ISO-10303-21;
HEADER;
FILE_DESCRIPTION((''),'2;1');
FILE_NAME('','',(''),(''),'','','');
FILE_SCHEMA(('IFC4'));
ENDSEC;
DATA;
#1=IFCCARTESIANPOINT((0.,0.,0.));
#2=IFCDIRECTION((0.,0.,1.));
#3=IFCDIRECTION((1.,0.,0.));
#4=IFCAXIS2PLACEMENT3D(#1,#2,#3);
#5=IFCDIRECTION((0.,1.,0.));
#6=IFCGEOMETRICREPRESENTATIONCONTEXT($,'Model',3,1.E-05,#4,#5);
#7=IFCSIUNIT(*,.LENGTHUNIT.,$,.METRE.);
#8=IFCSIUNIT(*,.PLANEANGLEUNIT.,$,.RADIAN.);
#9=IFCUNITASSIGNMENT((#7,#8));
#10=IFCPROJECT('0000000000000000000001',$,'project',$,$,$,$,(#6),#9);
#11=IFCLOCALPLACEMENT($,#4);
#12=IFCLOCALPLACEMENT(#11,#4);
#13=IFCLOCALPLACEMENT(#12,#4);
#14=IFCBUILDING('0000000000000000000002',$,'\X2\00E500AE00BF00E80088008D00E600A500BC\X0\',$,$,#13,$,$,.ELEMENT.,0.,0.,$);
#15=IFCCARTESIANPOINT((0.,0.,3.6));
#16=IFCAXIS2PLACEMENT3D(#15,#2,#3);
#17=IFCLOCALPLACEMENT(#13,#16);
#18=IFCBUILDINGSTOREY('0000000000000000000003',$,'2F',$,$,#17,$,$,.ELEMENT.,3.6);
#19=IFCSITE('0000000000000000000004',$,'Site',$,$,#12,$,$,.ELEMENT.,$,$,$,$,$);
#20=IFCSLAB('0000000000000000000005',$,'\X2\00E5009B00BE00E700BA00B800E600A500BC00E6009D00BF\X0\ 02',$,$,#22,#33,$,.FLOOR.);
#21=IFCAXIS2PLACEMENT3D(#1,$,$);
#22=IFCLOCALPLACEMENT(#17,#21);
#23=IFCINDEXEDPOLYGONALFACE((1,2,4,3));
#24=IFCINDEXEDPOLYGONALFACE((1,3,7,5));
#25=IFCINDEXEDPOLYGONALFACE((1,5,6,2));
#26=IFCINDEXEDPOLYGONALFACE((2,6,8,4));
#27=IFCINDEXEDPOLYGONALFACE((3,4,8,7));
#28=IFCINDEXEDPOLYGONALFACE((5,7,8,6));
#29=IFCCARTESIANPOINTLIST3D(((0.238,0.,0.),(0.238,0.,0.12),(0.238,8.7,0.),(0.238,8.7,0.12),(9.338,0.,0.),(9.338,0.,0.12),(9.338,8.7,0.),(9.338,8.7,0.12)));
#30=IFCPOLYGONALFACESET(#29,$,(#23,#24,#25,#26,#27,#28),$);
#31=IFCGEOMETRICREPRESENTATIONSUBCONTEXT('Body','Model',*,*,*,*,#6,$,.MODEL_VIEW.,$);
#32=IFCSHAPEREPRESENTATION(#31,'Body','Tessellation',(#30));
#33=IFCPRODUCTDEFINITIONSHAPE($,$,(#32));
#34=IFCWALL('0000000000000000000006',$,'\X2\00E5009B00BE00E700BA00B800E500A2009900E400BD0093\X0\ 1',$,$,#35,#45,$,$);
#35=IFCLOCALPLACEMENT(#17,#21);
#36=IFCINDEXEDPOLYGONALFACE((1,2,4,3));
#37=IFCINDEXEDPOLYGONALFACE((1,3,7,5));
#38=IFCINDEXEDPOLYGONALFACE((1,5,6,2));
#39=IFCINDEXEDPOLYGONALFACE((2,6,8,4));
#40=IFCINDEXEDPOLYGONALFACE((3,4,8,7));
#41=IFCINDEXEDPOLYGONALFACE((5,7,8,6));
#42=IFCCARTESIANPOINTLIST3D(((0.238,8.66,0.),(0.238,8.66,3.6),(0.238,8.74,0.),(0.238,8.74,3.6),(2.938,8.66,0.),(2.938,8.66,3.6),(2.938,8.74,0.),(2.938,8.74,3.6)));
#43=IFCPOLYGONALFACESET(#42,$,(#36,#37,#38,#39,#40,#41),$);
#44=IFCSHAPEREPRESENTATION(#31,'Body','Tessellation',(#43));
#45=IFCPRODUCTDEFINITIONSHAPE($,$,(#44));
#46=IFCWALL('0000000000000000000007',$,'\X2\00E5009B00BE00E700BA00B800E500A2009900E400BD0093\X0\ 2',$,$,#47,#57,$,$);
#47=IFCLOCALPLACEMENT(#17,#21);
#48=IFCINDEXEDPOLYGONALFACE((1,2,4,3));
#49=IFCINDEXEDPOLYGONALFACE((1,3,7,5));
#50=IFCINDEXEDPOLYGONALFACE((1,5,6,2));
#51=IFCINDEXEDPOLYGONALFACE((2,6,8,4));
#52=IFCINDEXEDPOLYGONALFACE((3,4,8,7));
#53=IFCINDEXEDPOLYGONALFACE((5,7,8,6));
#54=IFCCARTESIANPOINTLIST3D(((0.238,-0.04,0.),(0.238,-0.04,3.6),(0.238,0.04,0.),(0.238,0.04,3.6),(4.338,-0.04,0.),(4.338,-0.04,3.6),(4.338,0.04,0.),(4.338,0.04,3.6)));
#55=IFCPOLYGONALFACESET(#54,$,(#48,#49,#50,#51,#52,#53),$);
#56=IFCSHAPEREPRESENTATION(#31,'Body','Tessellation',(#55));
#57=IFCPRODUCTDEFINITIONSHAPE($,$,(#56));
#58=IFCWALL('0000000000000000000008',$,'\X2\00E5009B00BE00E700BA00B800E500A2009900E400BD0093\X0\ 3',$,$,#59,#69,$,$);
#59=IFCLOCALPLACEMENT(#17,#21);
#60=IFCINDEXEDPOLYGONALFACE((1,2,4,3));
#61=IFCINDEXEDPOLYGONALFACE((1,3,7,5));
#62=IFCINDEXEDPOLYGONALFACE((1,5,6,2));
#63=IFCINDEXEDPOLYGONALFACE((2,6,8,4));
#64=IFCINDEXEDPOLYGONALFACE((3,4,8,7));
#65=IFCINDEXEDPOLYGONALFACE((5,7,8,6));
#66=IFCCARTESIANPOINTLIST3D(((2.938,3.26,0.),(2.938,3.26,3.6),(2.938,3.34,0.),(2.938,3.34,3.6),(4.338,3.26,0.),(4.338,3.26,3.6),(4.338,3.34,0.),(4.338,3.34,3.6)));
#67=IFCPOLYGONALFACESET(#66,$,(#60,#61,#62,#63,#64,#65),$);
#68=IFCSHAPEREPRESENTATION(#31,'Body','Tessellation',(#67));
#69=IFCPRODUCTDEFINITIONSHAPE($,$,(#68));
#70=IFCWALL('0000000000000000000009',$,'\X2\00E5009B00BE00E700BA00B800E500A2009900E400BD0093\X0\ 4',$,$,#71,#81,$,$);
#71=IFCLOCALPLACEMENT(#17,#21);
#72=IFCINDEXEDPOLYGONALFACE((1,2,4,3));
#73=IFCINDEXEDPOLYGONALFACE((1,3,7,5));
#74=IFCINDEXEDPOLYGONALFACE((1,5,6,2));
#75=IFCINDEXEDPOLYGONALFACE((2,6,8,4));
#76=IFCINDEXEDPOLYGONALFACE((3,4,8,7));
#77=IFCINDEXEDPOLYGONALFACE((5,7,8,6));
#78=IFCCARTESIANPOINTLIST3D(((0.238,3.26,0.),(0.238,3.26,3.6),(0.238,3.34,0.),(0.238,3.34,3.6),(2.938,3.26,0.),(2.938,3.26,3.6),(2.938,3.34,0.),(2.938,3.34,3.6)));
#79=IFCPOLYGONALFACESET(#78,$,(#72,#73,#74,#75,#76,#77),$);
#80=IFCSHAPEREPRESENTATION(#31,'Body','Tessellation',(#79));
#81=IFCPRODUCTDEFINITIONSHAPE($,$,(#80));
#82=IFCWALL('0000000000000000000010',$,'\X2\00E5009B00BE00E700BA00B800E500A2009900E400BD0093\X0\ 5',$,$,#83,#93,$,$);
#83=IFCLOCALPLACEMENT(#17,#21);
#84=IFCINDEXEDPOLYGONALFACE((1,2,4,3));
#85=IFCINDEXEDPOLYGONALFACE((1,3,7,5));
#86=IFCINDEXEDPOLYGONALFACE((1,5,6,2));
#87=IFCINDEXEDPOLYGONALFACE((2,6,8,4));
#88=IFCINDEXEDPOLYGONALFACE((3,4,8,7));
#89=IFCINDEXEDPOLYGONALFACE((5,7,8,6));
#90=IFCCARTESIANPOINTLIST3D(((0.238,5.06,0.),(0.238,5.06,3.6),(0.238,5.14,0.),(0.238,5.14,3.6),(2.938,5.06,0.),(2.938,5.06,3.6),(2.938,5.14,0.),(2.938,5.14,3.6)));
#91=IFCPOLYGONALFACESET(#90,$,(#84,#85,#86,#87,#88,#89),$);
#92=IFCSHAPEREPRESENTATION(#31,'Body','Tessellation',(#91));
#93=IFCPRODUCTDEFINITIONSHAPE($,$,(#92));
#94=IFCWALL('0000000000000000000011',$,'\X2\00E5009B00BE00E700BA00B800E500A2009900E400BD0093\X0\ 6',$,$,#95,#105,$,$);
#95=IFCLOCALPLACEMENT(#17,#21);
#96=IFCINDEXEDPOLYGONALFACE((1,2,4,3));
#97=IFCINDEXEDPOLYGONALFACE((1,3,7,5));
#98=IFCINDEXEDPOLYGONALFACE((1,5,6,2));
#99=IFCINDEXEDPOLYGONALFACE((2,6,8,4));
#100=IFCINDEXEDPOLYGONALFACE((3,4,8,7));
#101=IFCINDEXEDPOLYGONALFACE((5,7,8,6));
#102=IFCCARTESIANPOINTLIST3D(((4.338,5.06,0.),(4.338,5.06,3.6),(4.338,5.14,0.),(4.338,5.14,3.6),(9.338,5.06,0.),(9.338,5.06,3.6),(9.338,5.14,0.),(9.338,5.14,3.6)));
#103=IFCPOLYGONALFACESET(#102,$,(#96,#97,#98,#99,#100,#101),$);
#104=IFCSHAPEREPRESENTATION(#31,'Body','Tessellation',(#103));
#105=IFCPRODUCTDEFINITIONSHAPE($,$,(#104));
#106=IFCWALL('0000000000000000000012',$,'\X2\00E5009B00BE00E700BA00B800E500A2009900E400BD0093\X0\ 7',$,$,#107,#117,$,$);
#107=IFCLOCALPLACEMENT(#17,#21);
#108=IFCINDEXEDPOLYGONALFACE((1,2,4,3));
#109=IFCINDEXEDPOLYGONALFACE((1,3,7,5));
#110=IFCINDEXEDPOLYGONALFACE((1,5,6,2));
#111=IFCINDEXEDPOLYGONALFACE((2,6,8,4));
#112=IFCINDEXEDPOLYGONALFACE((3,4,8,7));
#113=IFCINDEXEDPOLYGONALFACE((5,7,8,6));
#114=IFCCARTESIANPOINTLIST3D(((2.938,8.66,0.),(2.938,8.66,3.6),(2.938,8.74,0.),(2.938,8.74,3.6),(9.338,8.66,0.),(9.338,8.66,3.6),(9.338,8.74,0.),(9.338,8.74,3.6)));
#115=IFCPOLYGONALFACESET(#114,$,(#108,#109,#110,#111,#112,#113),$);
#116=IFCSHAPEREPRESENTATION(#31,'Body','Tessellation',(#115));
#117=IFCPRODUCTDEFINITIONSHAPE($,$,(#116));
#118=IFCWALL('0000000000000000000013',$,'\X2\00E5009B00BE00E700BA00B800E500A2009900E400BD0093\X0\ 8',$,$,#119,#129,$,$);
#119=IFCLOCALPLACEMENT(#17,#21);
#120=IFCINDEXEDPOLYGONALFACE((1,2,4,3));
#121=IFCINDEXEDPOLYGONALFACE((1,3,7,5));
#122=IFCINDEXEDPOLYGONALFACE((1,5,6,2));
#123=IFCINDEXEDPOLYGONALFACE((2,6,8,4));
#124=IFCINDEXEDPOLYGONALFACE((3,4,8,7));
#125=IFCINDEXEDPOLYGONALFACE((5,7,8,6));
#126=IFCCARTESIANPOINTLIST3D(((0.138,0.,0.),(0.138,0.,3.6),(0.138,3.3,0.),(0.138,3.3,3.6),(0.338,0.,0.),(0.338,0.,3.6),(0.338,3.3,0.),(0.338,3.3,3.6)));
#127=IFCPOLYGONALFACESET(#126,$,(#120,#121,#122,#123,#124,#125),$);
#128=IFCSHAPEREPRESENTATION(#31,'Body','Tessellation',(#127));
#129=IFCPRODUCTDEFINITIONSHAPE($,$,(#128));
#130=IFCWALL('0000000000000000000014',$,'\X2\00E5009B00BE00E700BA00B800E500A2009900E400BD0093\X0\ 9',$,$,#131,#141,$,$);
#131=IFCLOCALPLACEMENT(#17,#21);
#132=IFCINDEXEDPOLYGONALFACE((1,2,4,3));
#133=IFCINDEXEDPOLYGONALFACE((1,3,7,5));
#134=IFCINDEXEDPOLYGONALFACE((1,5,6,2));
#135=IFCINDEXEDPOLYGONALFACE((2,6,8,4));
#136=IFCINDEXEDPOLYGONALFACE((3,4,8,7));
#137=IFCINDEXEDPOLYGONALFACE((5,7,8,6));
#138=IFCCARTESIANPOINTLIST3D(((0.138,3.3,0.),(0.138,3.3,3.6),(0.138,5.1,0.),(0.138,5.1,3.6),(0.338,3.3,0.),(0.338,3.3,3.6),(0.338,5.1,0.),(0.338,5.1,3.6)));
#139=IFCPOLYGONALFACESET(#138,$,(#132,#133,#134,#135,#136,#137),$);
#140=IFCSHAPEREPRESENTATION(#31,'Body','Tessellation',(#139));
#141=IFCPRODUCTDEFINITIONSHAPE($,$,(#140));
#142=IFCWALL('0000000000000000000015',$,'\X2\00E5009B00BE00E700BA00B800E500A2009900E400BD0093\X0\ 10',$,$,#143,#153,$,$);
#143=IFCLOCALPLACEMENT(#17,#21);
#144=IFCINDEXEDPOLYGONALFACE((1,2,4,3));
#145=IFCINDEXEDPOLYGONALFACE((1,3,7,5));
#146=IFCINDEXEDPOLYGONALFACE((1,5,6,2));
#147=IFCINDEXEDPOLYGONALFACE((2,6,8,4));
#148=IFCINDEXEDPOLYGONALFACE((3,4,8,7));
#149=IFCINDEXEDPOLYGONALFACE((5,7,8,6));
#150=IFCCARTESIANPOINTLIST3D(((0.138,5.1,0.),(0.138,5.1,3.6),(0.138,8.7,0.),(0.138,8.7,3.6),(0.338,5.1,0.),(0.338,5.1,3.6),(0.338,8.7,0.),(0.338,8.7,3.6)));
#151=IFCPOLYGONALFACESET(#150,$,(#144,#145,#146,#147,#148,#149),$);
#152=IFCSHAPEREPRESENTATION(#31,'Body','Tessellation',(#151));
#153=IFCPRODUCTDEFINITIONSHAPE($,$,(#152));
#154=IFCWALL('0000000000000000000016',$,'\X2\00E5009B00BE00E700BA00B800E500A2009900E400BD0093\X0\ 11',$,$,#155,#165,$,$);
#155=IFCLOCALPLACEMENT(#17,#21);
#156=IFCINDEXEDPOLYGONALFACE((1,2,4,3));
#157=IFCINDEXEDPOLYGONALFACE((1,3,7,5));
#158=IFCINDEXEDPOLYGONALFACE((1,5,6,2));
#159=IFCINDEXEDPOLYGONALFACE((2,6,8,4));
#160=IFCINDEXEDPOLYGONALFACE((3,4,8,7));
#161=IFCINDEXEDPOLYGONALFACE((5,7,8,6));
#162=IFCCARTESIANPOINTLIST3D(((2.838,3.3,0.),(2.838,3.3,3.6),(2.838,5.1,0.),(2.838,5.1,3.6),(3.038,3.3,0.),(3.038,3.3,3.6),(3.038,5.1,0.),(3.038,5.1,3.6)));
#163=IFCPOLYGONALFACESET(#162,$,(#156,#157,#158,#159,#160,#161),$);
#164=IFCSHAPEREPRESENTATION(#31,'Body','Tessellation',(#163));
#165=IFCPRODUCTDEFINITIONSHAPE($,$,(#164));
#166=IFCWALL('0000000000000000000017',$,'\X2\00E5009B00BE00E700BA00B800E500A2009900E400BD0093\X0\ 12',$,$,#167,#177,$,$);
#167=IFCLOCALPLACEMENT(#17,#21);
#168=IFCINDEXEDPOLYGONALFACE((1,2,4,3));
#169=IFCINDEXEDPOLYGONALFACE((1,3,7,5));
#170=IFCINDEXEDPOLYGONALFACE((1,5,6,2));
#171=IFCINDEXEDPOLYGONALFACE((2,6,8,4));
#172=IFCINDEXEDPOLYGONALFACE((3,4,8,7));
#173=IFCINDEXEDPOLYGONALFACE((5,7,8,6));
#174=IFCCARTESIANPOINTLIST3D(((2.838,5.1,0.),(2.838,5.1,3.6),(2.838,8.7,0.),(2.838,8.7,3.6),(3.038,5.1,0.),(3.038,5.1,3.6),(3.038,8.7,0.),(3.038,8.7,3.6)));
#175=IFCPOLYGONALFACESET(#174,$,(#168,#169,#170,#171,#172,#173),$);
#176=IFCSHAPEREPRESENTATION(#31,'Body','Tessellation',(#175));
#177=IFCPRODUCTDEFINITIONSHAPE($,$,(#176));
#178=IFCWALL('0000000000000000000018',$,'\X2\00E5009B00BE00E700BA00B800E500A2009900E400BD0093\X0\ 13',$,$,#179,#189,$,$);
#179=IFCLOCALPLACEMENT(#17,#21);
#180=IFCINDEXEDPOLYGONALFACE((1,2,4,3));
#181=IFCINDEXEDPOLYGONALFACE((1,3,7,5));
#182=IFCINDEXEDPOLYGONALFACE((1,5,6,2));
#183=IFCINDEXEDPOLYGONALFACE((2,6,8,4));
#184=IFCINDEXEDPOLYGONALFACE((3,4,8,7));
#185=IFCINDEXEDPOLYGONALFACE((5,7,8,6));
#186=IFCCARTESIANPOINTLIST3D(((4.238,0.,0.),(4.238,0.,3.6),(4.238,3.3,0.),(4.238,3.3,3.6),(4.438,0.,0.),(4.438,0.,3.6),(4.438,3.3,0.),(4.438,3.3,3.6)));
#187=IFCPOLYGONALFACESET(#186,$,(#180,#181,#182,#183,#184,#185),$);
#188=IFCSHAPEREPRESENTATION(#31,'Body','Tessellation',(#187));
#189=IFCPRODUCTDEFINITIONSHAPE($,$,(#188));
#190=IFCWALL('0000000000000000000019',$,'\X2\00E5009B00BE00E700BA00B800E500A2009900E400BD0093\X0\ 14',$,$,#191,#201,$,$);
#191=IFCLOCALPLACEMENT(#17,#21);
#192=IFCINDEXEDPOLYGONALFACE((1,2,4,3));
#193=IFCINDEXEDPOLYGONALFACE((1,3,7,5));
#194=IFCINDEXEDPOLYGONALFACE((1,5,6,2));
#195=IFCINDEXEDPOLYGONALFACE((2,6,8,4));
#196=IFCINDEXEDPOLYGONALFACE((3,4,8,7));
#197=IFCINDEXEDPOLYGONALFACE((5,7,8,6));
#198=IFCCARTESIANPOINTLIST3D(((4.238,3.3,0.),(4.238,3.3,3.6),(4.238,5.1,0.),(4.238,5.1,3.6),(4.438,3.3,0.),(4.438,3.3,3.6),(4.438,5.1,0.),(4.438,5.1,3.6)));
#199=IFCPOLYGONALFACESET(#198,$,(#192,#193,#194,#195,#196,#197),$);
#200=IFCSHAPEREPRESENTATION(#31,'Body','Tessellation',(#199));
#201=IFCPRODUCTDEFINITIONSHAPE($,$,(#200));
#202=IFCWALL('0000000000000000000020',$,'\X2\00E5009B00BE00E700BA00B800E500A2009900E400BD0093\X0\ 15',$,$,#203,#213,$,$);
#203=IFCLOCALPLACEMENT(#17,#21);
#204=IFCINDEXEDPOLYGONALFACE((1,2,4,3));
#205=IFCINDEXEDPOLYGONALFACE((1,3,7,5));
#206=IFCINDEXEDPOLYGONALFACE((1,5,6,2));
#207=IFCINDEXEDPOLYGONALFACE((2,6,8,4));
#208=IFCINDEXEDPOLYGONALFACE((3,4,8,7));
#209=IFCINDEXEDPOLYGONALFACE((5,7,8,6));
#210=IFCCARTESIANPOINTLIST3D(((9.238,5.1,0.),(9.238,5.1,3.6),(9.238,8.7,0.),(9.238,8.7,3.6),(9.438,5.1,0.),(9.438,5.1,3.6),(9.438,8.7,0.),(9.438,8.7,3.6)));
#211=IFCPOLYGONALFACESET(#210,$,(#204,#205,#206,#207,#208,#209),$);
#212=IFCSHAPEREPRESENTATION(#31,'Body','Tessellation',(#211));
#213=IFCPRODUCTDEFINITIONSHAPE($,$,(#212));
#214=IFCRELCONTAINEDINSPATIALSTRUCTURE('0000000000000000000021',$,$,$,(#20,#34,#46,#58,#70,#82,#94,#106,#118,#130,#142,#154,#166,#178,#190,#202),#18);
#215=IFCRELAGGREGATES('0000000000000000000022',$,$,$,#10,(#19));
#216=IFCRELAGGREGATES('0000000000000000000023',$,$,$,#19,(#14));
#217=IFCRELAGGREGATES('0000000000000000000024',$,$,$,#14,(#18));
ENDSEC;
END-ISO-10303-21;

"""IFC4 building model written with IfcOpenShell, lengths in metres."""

from ifc_helpers import new_model, si_unit, direction, frame, frame_2d, origin_with_axes, place, context, subcontext, project, spatial, rectangle, extrude, element, save


model = new_model("IFC4")

# Units and contexts
model_context = context("Model", 3, precision=1e-05, world=origin_with_axes(), true_north=direction((0.0, 1.0, 0.0)))
body_context = subcontext(model_context, "Body", "Model", "MODEL_VIEW")
ifc_project = project(units=[si_unit("LENGTHUNIT", "METRE"), si_unit("PLANEANGLEUNIT", "RADIAN")], contexts=[model_context])

# Site, building, storey
placement = place(None, origin_with_axes())
site_placement = place(placement, origin_with_axes())
site = spatial("IfcSite", under=ifc_project, at=site_placement, Name="Site", CompositionType="ELEMENT")
building_placement = place(site_placement, origin_with_axes())
building = spatial("IfcBuilding", under=site, at=building_placement, Name="å®¿è\u0088\u008dæ¥¼", CompositionType="ELEMENT", ElevationOfRefHeight=0.0, ElevationOfTerrain=0.0)
storey_placement = place(building_placement, frame((0.0, 0.0, 3.6), z_axis=(0.0, 0.0, 1.0), x_axis=(1.0, 0.0, 0.0)))
storey = spatial("IfcBuildingStorey", under=building, at=storey_placement, Name="2F", CompositionType="ELEMENT", Elevation=3.6)

# Slab
slab_placement = place(storey_placement, frame((4.788, 4.35, 0.0), z_axis=(0.0, 0.0, 1.0), x_axis=(1.0, 0.0, 0.0)))
element("IfcSlab", 1, at=slab_placement, inside=storey, Name="å\u009b¾çº¸æ¥¼æ\u009d¿ 02", PredefinedType="FLOOR", context=body_context, shape_type="SweptSolid", body=[
    extrude(rectangle(XDim=9.1, YDim=8.7, at=frame_2d((0.0, 0.0), x_axis=(1.0, 0.0, 0.0))), frame((0.0, 0.0, 0.0), z_axis=(0.0, 0.0, 1.0)), (0.0, 0.0, 1.0), 0.12),
])

# Walls
wall_1_placement = place(storey_placement, frame((1.588, 8.7, 0.0), z_axis=(0.0, 0.0, 1.0), x_axis=(1.0, 0.0, 0.0)))
element("IfcWall", 2, at=wall_1_placement, inside=storey, Name="å\u009b¾çº¸å¢\u0099ä½\u0093 1", context=body_context, shape_type="SweptSolid", body=[
    extrude(rectangle(XDim=2.7, YDim=0.0801, at=frame_2d((0.0, 0.0), x_axis=(1.0, 0.0, 0.0))), frame((0.0, 0.0, 0.0), z_axis=(0.0, 0.0, 1.0)), (0.0, 0.0, 1.0), 3.6),
])
wall_2_placement = place(storey_placement, frame((2.288, 0.0, 0.0), z_axis=(0.0, 0.0, 1.0), x_axis=(1.0, 0.0, 0.0)))
element("IfcWall", 3, at=wall_2_placement, inside=storey, Name="å\u009b¾çº¸å¢\u0099ä½\u0093 2", context=body_context, shape_type="SweptSolid", body=[
    extrude(rectangle(XDim=4.1, YDim=0.0801, at=frame_2d((0.0, 0.0), x_axis=(1.0, 0.0, 0.0))), frame((0.0, 0.0, 0.0), z_axis=(0.0, 0.0, 1.0)), (0.0, 0.0, 1.0), 3.6),
])
wall_3_placement = place(storey_placement, frame((3.638, 3.3, 0.0), z_axis=(0.0, 0.0, 1.0), x_axis=(1.0, 0.0, 0.0)))
element("IfcWall", 4, at=wall_3_placement, inside=storey, Name="å\u009b¾çº¸å¢\u0099ä½\u0093 3", context=body_context, shape_type="SweptSolid", body=[
    extrude(rectangle(XDim=1.4, YDim=0.0801, at=frame_2d((0.0, 0.0), x_axis=(1.0, 0.0, 0.0))), frame((0.0, 0.0, 0.0), z_axis=(0.0, 0.0, 1.0)), (0.0, 0.0, 1.0), 3.6),
])
for number, where, z_axis, x_axis, name in (
    (5, (1.588, 3.3, 0.0), (0.0, 0.0, 1.0), (1.0, 0.0, 0.0), "å\u009b¾çº¸å¢\u0099ä½\u0093 4"),
    (6, (1.588, 5.1, 0.0), (0.0, 0.0, 1.0), (1.0, 0.0, 0.0), "å\u009b¾çº¸å¢\u0099ä½\u0093 5"),
):
    element("IfcWall", number, at=place(storey_placement, frame(where, z_axis=z_axis, x_axis=x_axis)), inside=storey, Name=name, context=body_context, shape_type="SweptSolid", body=[
        extrude(rectangle(XDim=2.7, YDim=0.0801, at=frame_2d((0.0, 0.0), x_axis=(1.0, 0.0, 0.0))), frame((0.0, 0.0, 0.0), z_axis=(0.0, 0.0, 1.0)), (0.0, 0.0, 1.0), 3.6),
    ])
wall_4_placement = place(storey_placement, frame((6.838, 5.1, 0.0), z_axis=(0.0, 0.0, 1.0), x_axis=(1.0, 0.0, 0.0)))
element("IfcWall", 7, at=wall_4_placement, inside=storey, Name="å\u009b¾çº¸å¢\u0099ä½\u0093 6", context=body_context, shape_type="SweptSolid", body=[
    extrude(rectangle(XDim=5.0, YDim=0.0801, at=frame_2d((0.0, 0.0), x_axis=(1.0, 0.0, 0.0))), frame((0.0, 0.0, 0.0), z_axis=(0.0, 0.0, 1.0)), (0.0, 0.0, 1.0), 3.6),
])
wall_5_placement = place(storey_placement, frame((6.138, 8.7, 0.0), z_axis=(0.0, 0.0, 1.0), x_axis=(-1.0, 0.0, 0.0)))
element("IfcWall", 8, at=wall_5_placement, inside=storey, Name="å\u009b¾çº¸å¢\u0099ä½\u0093 7", context=body_context, shape_type="SweptSolid", body=[
    extrude(rectangle(XDim=6.4, YDim=0.0801, at=frame_2d((0.0, 0.0), x_axis=(1.0, 0.0, 0.0))), frame((0.0, 0.0, 0.0), z_axis=(0.0, 0.0, 1.0)), (0.0, 0.0, 1.0), 3.6),
])
wall_6_placement = place(storey_placement, frame((0.238, 1.65, 0.0), z_axis=(0.0, 0.0, 1.0), x_axis=(0.0, 1.0, 0.0)))
element("IfcWall", 9, at=wall_6_placement, inside=storey, Name="å\u009b¾çº¸å¢\u0099ä½\u0093 8", context=body_context, shape_type="SweptSolid", body=[
    extrude(rectangle(XDim=3.3, YDim=0.2, at=frame_2d((0.0, 0.0), x_axis=(1.0, 0.0, 0.0))), frame((0.0, 0.0, 0.0), z_axis=(0.0, 0.0, 1.0)), (0.0, 0.0, 1.0), 3.6),
])
wall_7_placement = place(storey_placement, frame((0.238, 4.2, 0.0), z_axis=(0.0, 0.0, 1.0), x_axis=(0.0, 1.0, 0.0)))
element("IfcWall", 10, at=wall_7_placement, inside=storey, Name="å\u009b¾çº¸å¢\u0099ä½\u0093 9", context=body_context, shape_type="SweptSolid", body=[
    extrude(rectangle(XDim=1.8, YDim=0.2, at=frame_2d((0.0, 0.0), x_axis=(1.0, 0.0, 0.0))), frame((0.0, 0.0, 0.0), z_axis=(0.0, 0.0, 1.0)), (0.0, 0.0, 1.0), 3.6),
])
wall_8_placement = place(storey_placement, frame((0.238, 6.9, 0.0), z_axis=(0.0, 0.0, 1.0), x_axis=(0.0, 1.0, 0.0)))
element("IfcWall", 11, at=wall_8_placement, inside=storey, Name="å\u009b¾çº¸å¢\u0099ä½\u0093 10", context=body_context, shape_type="SweptSolid", body=[
    extrude(rectangle(XDim=3.6, YDim=0.2, at=frame_2d((0.0, 0.0), x_axis=(1.0, 0.0, 0.0))), frame((0.0, 0.0, 0.0), z_axis=(0.0, 0.0, 1.0)), (0.0, 0.0, 1.0), 3.6),
])
wall_9_placement = place(storey_placement, frame((2.938, 4.2, 0.0), z_axis=(0.0, 0.0, 1.0), x_axis=(0.0, 1.0, 0.0)))
element("IfcWall", 12, at=wall_9_placement, inside=storey, Name="å\u009b¾çº¸å¢\u0099ä½\u0093 11", context=body_context, shape_type="SweptSolid", body=[
    extrude(rectangle(XDim=1.8, YDim=0.2, at=frame_2d((0.0, 0.0), x_axis=(1.0, 0.0, 0.0))), frame((0.0, 0.0, 0.0), z_axis=(0.0, 0.0, 1.0)), (0.0, 0.0, 1.0), 3.6),
])
wall_10_placement = place(storey_placement, frame((2.938, 6.9, 0.0), z_axis=(0.0, 0.0, 1.0), x_axis=(0.0, 1.0, 0.0)))
element("IfcWall", 13, at=wall_10_placement, inside=storey, Name="å\u009b¾çº¸å¢\u0099ä½\u0093 12", context=body_context, shape_type="SweptSolid", body=[
    extrude(rectangle(XDim=3.6, YDim=0.2, at=frame_2d((0.0, 0.0), x_axis=(1.0, 0.0, 0.0))), frame((0.0, 0.0, 0.0), z_axis=(0.0, 0.0, 1.0)), (0.0, 0.0, 1.0), 3.6),
])
wall_11_placement = place(storey_placement, frame((4.338, 1.65, 0.0), z_axis=(0.0, 0.0, 1.0), x_axis=(0.0, 1.0, 0.0)))
element("IfcWall", 14, at=wall_11_placement, inside=storey, Name="å\u009b¾çº¸å¢\u0099ä½\u0093 13", context=body_context, shape_type="SweptSolid", body=[
    extrude(rectangle(XDim=3.3, YDim=0.2, at=frame_2d((0.0, 0.0), x_axis=(1.0, 0.0, 0.0))), frame((0.0, 0.0, 0.0), z_axis=(0.0, 0.0, 1.0)), (0.0, 0.0, 1.0), 3.6),
])
wall_12_placement = place(storey_placement, frame((4.338, 4.2, 0.0), z_axis=(0.0, 0.0, 1.0), x_axis=(0.0, 1.0, 0.0)))
element("IfcWall", 15, at=wall_12_placement, inside=storey, Name="å\u009b¾çº¸å¢\u0099ä½\u0093 14", context=body_context, shape_type="SweptSolid", body=[
    extrude(rectangle(XDim=1.8, YDim=0.2, at=frame_2d((0.0, 0.0), x_axis=(1.0, 0.0, 0.0))), frame((0.0, 0.0, 0.0), z_axis=(0.0, 0.0, 1.0)), (0.0, 0.0, 1.0), 3.6),
])
wall_13_placement = place(storey_placement, frame((9.338, 6.9, 0.0), z_axis=(0.0, 0.0, 1.0), x_axis=(0.0, 1.0, 0.0)))
element("IfcWall", 16, at=wall_13_placement, inside=storey, Name="å\u009b¾çº¸å¢\u0099ä½\u0093 15", context=body_context, shape_type="SweptSolid", body=[
    extrude(rectangle(XDim=3.6, YDim=0.2, at=frame_2d((0.0, 0.0), x_axis=(1.0, 0.0, 0.0))), frame((0.0, 0.0, 0.0), z_axis=(0.0, 0.0, 1.0)), (0.0, 0.0, 1.0), 3.6),
])

save(model, "model.ifc")
